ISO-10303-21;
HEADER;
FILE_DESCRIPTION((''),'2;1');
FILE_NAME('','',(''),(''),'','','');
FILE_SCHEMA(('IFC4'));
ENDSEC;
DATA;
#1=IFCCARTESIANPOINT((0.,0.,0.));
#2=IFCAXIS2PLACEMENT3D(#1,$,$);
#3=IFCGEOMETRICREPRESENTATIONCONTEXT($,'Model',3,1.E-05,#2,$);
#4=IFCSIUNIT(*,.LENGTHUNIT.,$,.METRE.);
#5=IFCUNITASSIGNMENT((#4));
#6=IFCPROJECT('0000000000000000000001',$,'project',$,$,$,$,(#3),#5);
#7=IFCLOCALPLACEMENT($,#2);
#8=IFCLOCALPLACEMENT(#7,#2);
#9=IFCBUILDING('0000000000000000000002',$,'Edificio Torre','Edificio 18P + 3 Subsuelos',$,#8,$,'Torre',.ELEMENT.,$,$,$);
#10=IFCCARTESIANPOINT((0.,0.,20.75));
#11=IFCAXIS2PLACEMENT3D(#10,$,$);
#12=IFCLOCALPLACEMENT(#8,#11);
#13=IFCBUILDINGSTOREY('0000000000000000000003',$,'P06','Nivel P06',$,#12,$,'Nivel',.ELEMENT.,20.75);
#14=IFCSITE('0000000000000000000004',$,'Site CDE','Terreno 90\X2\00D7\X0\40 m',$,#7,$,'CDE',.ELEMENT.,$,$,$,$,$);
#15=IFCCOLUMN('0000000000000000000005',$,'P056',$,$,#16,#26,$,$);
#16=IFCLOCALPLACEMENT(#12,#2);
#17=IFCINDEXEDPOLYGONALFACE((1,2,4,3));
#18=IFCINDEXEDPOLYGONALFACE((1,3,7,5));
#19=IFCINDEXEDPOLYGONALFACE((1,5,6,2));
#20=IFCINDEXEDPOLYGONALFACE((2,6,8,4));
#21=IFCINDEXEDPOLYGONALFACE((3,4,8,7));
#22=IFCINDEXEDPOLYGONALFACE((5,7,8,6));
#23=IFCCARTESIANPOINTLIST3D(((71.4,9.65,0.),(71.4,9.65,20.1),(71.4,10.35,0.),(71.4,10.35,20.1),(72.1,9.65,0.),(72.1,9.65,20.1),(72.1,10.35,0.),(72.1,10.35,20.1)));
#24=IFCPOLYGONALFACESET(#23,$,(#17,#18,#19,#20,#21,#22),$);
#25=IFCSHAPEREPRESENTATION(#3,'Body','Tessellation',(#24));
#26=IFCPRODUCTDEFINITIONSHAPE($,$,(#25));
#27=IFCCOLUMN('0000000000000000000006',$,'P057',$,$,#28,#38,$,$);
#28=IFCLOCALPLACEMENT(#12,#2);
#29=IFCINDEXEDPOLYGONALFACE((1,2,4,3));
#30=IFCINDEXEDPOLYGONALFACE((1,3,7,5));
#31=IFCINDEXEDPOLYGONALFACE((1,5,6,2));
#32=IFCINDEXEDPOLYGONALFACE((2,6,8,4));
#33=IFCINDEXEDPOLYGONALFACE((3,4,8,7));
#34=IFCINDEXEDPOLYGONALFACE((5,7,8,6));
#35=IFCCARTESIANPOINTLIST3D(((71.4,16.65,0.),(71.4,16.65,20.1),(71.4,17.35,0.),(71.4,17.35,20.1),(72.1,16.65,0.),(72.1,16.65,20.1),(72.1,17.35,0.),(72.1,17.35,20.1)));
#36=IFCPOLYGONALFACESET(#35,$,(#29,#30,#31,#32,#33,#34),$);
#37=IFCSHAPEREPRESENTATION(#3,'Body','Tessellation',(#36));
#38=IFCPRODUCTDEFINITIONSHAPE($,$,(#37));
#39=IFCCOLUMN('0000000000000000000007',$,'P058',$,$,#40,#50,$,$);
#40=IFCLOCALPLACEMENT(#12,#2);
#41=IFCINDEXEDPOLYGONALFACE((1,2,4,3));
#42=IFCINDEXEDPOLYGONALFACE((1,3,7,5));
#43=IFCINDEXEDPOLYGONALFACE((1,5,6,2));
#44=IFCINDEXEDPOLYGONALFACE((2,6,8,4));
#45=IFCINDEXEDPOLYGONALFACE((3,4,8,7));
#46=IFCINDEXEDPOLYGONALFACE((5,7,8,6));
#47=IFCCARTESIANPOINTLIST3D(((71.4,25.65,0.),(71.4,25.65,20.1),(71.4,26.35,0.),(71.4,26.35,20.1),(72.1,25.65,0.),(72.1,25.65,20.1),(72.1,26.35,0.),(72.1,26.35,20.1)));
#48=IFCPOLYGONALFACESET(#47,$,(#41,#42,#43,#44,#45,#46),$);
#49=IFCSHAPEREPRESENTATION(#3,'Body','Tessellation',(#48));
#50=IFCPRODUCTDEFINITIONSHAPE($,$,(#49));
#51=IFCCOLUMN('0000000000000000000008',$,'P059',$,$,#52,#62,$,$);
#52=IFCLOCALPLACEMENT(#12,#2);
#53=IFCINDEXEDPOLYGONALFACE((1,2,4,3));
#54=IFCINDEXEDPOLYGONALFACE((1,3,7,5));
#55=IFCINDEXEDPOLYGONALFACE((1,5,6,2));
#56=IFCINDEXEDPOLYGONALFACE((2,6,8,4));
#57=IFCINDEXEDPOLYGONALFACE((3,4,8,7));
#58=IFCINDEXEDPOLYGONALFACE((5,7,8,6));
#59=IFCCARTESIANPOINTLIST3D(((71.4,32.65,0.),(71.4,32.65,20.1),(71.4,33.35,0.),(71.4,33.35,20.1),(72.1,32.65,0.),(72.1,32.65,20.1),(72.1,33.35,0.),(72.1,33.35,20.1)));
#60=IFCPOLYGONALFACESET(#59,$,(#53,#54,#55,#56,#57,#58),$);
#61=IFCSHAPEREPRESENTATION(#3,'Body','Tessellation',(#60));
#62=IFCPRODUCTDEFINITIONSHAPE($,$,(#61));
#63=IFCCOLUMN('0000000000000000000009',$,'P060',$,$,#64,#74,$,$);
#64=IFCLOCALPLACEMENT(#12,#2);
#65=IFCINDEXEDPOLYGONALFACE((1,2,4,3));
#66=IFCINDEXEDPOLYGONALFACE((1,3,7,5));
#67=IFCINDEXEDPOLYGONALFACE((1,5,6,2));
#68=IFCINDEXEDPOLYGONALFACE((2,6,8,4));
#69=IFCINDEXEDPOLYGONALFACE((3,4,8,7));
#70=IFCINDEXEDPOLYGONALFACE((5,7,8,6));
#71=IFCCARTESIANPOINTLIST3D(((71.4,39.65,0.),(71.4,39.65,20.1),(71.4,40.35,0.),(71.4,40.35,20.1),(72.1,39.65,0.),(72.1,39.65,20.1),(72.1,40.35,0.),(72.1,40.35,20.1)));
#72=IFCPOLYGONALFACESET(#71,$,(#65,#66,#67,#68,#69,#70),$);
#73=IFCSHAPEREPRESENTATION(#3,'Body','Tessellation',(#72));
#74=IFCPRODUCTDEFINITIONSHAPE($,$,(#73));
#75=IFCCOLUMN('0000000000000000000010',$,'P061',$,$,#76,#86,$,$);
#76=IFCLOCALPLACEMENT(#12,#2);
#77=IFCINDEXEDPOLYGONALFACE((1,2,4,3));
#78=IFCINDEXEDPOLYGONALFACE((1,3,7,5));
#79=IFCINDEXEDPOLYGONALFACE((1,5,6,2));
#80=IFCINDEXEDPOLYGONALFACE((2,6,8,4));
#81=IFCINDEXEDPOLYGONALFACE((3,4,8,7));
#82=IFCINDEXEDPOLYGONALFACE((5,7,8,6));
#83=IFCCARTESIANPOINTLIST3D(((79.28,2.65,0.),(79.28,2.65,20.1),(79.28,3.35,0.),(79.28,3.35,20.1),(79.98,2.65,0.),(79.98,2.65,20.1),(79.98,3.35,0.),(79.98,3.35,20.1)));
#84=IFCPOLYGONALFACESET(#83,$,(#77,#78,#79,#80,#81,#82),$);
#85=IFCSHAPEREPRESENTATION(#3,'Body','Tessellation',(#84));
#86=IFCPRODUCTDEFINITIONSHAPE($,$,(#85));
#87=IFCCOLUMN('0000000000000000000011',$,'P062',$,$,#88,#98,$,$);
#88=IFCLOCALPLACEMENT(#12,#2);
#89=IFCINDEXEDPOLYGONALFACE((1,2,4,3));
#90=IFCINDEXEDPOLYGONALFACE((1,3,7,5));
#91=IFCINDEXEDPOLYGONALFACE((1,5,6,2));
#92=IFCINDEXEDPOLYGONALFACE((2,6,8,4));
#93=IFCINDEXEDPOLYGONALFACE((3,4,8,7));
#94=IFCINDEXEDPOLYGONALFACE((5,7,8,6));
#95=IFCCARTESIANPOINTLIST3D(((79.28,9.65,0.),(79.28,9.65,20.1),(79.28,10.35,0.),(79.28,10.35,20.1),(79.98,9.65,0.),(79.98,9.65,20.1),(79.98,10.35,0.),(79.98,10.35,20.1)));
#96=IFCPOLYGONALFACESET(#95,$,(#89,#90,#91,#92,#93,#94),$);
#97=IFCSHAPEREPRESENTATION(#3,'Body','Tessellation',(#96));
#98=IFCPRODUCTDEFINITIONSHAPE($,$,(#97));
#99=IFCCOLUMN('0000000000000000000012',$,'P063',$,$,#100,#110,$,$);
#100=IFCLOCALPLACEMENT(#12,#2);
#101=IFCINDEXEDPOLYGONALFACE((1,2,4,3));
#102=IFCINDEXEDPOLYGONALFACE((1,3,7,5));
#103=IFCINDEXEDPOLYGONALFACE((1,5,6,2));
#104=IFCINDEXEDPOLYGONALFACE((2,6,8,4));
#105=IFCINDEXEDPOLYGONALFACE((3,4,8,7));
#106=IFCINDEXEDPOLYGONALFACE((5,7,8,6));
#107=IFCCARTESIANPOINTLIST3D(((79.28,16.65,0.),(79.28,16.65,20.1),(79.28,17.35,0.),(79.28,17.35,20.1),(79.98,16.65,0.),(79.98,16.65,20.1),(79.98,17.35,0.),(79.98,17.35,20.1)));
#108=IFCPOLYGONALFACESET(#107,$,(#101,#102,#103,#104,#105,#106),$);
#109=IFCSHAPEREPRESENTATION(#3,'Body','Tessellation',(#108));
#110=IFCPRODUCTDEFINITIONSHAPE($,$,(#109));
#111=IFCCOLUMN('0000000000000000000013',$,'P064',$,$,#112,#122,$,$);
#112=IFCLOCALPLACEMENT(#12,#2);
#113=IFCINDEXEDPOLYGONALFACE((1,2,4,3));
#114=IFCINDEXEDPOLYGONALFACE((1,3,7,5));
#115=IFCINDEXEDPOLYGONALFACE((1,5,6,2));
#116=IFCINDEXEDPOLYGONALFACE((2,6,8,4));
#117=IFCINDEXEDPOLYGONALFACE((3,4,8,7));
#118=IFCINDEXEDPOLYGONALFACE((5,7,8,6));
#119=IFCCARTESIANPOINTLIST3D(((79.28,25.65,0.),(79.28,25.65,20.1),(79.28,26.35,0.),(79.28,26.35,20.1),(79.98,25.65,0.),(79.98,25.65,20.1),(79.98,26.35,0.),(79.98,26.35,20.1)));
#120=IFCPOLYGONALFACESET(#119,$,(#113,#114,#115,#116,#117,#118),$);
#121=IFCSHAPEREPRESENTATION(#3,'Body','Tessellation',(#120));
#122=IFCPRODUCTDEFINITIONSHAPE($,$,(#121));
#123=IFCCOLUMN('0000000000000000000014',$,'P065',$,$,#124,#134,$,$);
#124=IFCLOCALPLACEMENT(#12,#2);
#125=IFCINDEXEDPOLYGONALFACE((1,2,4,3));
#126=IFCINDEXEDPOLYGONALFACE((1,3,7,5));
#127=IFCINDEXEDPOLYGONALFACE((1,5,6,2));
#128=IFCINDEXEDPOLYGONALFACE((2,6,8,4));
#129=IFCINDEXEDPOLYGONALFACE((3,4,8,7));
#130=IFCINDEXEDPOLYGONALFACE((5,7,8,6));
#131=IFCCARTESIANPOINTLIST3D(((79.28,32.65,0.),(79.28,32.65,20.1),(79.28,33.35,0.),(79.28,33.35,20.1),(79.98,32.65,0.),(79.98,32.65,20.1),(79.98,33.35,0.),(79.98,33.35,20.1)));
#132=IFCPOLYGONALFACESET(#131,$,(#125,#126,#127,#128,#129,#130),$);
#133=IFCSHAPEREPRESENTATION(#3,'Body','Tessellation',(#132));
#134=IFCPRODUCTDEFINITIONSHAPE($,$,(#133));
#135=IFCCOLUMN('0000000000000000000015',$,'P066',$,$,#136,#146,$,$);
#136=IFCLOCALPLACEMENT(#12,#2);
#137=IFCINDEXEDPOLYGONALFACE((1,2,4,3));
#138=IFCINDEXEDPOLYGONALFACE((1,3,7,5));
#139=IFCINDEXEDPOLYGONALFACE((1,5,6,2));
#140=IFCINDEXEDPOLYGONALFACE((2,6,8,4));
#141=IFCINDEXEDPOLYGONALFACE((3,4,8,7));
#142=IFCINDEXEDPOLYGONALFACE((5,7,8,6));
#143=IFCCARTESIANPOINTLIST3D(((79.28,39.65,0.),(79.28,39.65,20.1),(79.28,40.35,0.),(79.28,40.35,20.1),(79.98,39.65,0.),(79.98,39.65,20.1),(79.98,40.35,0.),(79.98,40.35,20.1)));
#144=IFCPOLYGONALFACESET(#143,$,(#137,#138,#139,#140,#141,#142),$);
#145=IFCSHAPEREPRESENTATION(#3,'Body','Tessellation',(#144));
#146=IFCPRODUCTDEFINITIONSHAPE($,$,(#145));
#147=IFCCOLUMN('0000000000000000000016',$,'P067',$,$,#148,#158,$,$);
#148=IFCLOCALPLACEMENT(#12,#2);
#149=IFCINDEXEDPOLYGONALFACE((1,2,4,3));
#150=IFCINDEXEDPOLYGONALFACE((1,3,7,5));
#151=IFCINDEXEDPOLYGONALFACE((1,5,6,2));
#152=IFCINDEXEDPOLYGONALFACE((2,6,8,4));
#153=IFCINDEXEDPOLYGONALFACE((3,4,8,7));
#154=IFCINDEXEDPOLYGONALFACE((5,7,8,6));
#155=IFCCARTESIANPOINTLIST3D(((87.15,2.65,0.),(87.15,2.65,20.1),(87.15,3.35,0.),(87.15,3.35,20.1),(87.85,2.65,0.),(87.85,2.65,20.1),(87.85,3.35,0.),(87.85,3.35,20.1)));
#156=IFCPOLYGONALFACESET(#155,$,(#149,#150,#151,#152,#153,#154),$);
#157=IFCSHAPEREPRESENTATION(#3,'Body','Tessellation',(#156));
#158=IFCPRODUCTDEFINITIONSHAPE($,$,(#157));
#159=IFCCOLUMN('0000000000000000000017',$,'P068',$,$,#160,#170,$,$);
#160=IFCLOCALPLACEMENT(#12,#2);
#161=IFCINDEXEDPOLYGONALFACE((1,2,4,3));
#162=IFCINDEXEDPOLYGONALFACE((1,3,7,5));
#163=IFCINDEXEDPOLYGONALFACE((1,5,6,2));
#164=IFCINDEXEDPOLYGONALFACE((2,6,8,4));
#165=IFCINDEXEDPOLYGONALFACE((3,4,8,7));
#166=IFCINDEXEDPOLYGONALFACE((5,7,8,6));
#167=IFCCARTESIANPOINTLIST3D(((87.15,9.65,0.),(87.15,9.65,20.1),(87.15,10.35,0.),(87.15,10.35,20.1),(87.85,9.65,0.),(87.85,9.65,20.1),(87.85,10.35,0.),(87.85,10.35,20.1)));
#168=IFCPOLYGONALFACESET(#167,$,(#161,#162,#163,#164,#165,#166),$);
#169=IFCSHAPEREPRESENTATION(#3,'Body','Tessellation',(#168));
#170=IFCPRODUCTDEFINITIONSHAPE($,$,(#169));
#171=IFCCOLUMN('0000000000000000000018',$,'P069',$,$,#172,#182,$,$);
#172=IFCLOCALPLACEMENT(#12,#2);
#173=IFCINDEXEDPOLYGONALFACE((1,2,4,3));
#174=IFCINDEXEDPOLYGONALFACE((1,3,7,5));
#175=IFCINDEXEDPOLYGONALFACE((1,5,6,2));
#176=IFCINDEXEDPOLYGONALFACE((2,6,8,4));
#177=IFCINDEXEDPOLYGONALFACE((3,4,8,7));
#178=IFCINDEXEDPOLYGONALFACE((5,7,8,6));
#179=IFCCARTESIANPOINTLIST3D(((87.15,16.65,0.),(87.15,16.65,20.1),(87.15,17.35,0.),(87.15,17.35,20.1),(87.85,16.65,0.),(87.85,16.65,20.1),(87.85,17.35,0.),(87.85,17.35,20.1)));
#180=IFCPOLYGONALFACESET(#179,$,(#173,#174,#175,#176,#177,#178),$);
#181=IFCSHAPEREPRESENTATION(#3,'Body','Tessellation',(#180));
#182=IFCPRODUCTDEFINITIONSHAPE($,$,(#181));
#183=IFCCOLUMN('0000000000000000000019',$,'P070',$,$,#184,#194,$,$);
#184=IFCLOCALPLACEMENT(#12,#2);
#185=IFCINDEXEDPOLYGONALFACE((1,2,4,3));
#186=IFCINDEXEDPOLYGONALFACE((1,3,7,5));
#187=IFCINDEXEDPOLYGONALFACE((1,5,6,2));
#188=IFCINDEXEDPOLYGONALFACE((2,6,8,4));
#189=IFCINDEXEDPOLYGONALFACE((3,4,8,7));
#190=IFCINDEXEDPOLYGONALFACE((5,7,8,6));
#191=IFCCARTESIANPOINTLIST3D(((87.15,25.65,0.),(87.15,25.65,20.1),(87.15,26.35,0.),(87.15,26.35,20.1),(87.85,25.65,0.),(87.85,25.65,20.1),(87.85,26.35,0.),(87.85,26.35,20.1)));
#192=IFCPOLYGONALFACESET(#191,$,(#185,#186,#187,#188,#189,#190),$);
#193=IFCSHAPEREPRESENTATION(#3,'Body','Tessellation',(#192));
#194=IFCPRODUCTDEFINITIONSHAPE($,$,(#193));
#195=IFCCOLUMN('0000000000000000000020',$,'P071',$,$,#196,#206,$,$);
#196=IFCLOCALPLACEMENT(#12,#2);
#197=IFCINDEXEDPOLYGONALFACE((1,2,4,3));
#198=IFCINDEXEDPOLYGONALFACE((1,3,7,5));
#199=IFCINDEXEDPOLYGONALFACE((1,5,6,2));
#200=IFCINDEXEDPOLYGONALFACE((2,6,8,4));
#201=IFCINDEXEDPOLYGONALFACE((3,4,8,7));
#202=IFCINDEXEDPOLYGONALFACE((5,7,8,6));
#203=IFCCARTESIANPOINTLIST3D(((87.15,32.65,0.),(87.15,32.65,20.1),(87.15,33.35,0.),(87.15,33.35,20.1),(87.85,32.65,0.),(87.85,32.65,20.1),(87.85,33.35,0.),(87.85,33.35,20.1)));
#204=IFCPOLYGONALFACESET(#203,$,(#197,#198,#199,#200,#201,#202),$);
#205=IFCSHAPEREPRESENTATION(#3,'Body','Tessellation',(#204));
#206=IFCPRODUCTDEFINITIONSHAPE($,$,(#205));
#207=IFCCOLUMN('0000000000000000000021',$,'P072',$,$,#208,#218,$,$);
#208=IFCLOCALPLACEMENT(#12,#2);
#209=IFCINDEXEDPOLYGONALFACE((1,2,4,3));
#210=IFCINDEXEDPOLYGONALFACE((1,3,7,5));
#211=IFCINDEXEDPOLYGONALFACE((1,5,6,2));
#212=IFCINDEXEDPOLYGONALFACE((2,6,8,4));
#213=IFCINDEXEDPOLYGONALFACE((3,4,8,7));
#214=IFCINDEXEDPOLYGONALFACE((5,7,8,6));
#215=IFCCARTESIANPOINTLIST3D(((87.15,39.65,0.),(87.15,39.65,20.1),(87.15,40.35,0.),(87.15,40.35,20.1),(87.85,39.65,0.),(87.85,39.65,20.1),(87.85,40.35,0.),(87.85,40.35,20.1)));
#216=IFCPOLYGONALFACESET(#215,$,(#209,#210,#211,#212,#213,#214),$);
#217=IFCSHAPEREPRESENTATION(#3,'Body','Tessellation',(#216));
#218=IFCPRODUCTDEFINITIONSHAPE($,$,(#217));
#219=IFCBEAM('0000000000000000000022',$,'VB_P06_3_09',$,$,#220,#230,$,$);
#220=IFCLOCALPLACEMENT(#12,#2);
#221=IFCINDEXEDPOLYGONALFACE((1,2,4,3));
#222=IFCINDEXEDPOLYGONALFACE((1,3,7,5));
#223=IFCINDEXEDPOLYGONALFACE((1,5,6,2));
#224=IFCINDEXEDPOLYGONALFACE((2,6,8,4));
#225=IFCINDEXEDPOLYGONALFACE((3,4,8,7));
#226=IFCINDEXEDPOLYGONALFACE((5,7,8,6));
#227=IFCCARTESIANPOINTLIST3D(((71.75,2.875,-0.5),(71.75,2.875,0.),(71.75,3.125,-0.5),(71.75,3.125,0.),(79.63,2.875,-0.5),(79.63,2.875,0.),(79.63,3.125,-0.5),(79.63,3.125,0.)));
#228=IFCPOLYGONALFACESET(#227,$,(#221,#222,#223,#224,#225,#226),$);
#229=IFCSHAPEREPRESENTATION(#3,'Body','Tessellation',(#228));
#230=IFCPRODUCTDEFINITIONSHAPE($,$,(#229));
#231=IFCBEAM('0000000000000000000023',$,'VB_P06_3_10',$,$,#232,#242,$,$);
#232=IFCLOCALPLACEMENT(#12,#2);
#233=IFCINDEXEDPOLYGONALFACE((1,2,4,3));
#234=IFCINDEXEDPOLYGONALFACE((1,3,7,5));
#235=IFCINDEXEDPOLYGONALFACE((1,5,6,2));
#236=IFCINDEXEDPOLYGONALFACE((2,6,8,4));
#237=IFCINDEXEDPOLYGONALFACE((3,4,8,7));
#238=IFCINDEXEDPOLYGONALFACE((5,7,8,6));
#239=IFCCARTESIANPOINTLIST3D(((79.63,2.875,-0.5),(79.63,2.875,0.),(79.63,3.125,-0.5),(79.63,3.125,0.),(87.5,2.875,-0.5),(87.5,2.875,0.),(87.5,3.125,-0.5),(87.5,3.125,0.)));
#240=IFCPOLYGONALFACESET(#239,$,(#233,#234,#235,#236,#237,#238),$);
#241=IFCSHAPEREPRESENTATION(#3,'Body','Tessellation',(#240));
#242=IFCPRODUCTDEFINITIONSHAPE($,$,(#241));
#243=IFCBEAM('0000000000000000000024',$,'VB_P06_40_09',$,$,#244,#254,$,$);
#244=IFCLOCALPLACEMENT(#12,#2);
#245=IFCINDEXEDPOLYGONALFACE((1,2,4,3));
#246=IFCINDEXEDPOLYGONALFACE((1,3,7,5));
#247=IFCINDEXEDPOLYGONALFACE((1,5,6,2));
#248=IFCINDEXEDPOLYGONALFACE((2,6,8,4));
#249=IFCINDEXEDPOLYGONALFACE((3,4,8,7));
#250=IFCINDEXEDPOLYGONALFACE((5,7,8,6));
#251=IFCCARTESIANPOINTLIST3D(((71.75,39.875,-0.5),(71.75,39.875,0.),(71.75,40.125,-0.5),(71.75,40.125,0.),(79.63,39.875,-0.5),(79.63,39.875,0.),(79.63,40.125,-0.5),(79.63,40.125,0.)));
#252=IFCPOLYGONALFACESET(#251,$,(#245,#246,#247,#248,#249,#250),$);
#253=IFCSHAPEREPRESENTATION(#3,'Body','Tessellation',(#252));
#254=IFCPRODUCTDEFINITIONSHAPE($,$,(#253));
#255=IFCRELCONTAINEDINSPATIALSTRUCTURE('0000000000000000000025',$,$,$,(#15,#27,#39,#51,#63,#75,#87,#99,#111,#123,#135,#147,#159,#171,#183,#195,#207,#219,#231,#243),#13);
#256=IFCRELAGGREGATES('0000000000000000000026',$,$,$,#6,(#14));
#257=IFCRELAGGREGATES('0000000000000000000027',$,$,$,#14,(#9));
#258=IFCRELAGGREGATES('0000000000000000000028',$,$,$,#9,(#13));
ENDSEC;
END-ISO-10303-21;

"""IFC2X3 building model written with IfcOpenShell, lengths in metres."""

from ifc_helpers import new_model, si_unit, frame, origin, origin_2d, place, context, project, spatial, rectangle, extrude, element, save


model = new_model("IFC2X3")

# Units and contexts
model_context = context("Model", 3, precision=1e-05, world=origin())
ifc_project = project(units=[si_unit("LENGTHUNIT", "METRE")], contexts=[model_context])

# Site, building, storey
site_placement = place(None, origin())
site = spatial("IfcSite", under=ifc_project, at=site_placement, Name="Site CDE", Description="Terreno 90×40 m", LongName="CDE", CompositionType="ELEMENT")
building_placement = place(site_placement, origin())
building = spatial("IfcBuilding", under=site, at=building_placement, Name="Edificio Torre", Description="Edificio 18P + 3 Subsuelos", LongName="Torre", CompositionType="ELEMENT")
storey_placement = place(building_placement, frame((0.0, 0.0, 20.75)))
storey = spatial("IfcBuildingStorey", under=building, at=storey_placement, Name="P06", Description="Nivel P06", LongName="Nivel", CompositionType="ELEMENT", Elevation=20.75)

# Columns
for number, where, name in (
    (1, (71.75, 10.0, 0.0), "P056"),
    (2, (71.75, 17.0, 0.0), "P057"),
    (3, (71.75, 26.0, 0.0), "P058"),
    (4, (71.75, 33.0, 0.0), "P059"),
    (5, (71.75, 40.0, 0.0), "P060"),
    (6, (79.63, 3.0, 0.0), "P061"),
    (7, (79.63, 10.0, 0.0), "P062"),
    (8, (79.63, 17.0, 0.0), "P063"),
    (9, (79.63, 26.0, 0.0), "P064"),
    (10, (79.63, 33.0, 0.0), "P065"),
    (11, (79.63, 40.0, 0.0), "P066"),
    (12, (87.5, 3.0, 0.0), "P067"),
    (13, (87.5, 10.0, 0.0), "P068"),
    (14, (87.5, 17.0, 0.0), "P069"),
    (15, (87.5, 26.0, 0.0), "P070"),
    (16, (87.5, 33.0, 0.0), "P071"),
    (17, (87.5, 40.0, 0.0), "P072"),
):
    element("IfcColumn", number, at=place(storey_placement, frame(where)), inside=storey, Name=name, context=model_context, shape_type="SweptSolid", body=[
        extrude(rectangle(XDim=0.7, YDim=0.7, at=origin_2d()), origin(), (0.0, 0.0, 1.0), 20.1),
    ])

# Beams
beam_1_placement = place(storey_placement, frame((75.69, 3.0, -0.5)))
element("IfcBeam", 18, at=beam_1_placement, inside=storey, Name="VB_P06_3_09", context=model_context, shape_type="SweptSolid", body=[
    extrude(rectangle(XDim=7.88, YDim=0.25, at=origin_2d()), origin(), (0.0, 0.0, 1.0), 0.5),
])
beam_2_placement = place(storey_placement, frame((83.565, 3.0, -0.5)))
element("IfcBeam", 19, at=beam_2_placement, inside=storey, Name="VB_P06_3_10", context=model_context, shape_type="SweptSolid", body=[
    extrude(rectangle(XDim=7.87, YDim=0.25, at=origin_2d()), origin(), (0.0, 0.0, 1.0), 0.5),
])
beam_3_placement = place(storey_placement, frame((75.69, 40.0, -0.5)))
element("IfcBeam", 20, at=beam_3_placement, inside=storey, Name="VB_P06_40_09", context=model_context, shape_type="SweptSolid", body=[
    extrude(rectangle(XDim=7.88, YDim=0.25, at=origin_2d()), origin(), (0.0, 0.0, 1.0), 0.5),
])

save(model, "model.ifc")
